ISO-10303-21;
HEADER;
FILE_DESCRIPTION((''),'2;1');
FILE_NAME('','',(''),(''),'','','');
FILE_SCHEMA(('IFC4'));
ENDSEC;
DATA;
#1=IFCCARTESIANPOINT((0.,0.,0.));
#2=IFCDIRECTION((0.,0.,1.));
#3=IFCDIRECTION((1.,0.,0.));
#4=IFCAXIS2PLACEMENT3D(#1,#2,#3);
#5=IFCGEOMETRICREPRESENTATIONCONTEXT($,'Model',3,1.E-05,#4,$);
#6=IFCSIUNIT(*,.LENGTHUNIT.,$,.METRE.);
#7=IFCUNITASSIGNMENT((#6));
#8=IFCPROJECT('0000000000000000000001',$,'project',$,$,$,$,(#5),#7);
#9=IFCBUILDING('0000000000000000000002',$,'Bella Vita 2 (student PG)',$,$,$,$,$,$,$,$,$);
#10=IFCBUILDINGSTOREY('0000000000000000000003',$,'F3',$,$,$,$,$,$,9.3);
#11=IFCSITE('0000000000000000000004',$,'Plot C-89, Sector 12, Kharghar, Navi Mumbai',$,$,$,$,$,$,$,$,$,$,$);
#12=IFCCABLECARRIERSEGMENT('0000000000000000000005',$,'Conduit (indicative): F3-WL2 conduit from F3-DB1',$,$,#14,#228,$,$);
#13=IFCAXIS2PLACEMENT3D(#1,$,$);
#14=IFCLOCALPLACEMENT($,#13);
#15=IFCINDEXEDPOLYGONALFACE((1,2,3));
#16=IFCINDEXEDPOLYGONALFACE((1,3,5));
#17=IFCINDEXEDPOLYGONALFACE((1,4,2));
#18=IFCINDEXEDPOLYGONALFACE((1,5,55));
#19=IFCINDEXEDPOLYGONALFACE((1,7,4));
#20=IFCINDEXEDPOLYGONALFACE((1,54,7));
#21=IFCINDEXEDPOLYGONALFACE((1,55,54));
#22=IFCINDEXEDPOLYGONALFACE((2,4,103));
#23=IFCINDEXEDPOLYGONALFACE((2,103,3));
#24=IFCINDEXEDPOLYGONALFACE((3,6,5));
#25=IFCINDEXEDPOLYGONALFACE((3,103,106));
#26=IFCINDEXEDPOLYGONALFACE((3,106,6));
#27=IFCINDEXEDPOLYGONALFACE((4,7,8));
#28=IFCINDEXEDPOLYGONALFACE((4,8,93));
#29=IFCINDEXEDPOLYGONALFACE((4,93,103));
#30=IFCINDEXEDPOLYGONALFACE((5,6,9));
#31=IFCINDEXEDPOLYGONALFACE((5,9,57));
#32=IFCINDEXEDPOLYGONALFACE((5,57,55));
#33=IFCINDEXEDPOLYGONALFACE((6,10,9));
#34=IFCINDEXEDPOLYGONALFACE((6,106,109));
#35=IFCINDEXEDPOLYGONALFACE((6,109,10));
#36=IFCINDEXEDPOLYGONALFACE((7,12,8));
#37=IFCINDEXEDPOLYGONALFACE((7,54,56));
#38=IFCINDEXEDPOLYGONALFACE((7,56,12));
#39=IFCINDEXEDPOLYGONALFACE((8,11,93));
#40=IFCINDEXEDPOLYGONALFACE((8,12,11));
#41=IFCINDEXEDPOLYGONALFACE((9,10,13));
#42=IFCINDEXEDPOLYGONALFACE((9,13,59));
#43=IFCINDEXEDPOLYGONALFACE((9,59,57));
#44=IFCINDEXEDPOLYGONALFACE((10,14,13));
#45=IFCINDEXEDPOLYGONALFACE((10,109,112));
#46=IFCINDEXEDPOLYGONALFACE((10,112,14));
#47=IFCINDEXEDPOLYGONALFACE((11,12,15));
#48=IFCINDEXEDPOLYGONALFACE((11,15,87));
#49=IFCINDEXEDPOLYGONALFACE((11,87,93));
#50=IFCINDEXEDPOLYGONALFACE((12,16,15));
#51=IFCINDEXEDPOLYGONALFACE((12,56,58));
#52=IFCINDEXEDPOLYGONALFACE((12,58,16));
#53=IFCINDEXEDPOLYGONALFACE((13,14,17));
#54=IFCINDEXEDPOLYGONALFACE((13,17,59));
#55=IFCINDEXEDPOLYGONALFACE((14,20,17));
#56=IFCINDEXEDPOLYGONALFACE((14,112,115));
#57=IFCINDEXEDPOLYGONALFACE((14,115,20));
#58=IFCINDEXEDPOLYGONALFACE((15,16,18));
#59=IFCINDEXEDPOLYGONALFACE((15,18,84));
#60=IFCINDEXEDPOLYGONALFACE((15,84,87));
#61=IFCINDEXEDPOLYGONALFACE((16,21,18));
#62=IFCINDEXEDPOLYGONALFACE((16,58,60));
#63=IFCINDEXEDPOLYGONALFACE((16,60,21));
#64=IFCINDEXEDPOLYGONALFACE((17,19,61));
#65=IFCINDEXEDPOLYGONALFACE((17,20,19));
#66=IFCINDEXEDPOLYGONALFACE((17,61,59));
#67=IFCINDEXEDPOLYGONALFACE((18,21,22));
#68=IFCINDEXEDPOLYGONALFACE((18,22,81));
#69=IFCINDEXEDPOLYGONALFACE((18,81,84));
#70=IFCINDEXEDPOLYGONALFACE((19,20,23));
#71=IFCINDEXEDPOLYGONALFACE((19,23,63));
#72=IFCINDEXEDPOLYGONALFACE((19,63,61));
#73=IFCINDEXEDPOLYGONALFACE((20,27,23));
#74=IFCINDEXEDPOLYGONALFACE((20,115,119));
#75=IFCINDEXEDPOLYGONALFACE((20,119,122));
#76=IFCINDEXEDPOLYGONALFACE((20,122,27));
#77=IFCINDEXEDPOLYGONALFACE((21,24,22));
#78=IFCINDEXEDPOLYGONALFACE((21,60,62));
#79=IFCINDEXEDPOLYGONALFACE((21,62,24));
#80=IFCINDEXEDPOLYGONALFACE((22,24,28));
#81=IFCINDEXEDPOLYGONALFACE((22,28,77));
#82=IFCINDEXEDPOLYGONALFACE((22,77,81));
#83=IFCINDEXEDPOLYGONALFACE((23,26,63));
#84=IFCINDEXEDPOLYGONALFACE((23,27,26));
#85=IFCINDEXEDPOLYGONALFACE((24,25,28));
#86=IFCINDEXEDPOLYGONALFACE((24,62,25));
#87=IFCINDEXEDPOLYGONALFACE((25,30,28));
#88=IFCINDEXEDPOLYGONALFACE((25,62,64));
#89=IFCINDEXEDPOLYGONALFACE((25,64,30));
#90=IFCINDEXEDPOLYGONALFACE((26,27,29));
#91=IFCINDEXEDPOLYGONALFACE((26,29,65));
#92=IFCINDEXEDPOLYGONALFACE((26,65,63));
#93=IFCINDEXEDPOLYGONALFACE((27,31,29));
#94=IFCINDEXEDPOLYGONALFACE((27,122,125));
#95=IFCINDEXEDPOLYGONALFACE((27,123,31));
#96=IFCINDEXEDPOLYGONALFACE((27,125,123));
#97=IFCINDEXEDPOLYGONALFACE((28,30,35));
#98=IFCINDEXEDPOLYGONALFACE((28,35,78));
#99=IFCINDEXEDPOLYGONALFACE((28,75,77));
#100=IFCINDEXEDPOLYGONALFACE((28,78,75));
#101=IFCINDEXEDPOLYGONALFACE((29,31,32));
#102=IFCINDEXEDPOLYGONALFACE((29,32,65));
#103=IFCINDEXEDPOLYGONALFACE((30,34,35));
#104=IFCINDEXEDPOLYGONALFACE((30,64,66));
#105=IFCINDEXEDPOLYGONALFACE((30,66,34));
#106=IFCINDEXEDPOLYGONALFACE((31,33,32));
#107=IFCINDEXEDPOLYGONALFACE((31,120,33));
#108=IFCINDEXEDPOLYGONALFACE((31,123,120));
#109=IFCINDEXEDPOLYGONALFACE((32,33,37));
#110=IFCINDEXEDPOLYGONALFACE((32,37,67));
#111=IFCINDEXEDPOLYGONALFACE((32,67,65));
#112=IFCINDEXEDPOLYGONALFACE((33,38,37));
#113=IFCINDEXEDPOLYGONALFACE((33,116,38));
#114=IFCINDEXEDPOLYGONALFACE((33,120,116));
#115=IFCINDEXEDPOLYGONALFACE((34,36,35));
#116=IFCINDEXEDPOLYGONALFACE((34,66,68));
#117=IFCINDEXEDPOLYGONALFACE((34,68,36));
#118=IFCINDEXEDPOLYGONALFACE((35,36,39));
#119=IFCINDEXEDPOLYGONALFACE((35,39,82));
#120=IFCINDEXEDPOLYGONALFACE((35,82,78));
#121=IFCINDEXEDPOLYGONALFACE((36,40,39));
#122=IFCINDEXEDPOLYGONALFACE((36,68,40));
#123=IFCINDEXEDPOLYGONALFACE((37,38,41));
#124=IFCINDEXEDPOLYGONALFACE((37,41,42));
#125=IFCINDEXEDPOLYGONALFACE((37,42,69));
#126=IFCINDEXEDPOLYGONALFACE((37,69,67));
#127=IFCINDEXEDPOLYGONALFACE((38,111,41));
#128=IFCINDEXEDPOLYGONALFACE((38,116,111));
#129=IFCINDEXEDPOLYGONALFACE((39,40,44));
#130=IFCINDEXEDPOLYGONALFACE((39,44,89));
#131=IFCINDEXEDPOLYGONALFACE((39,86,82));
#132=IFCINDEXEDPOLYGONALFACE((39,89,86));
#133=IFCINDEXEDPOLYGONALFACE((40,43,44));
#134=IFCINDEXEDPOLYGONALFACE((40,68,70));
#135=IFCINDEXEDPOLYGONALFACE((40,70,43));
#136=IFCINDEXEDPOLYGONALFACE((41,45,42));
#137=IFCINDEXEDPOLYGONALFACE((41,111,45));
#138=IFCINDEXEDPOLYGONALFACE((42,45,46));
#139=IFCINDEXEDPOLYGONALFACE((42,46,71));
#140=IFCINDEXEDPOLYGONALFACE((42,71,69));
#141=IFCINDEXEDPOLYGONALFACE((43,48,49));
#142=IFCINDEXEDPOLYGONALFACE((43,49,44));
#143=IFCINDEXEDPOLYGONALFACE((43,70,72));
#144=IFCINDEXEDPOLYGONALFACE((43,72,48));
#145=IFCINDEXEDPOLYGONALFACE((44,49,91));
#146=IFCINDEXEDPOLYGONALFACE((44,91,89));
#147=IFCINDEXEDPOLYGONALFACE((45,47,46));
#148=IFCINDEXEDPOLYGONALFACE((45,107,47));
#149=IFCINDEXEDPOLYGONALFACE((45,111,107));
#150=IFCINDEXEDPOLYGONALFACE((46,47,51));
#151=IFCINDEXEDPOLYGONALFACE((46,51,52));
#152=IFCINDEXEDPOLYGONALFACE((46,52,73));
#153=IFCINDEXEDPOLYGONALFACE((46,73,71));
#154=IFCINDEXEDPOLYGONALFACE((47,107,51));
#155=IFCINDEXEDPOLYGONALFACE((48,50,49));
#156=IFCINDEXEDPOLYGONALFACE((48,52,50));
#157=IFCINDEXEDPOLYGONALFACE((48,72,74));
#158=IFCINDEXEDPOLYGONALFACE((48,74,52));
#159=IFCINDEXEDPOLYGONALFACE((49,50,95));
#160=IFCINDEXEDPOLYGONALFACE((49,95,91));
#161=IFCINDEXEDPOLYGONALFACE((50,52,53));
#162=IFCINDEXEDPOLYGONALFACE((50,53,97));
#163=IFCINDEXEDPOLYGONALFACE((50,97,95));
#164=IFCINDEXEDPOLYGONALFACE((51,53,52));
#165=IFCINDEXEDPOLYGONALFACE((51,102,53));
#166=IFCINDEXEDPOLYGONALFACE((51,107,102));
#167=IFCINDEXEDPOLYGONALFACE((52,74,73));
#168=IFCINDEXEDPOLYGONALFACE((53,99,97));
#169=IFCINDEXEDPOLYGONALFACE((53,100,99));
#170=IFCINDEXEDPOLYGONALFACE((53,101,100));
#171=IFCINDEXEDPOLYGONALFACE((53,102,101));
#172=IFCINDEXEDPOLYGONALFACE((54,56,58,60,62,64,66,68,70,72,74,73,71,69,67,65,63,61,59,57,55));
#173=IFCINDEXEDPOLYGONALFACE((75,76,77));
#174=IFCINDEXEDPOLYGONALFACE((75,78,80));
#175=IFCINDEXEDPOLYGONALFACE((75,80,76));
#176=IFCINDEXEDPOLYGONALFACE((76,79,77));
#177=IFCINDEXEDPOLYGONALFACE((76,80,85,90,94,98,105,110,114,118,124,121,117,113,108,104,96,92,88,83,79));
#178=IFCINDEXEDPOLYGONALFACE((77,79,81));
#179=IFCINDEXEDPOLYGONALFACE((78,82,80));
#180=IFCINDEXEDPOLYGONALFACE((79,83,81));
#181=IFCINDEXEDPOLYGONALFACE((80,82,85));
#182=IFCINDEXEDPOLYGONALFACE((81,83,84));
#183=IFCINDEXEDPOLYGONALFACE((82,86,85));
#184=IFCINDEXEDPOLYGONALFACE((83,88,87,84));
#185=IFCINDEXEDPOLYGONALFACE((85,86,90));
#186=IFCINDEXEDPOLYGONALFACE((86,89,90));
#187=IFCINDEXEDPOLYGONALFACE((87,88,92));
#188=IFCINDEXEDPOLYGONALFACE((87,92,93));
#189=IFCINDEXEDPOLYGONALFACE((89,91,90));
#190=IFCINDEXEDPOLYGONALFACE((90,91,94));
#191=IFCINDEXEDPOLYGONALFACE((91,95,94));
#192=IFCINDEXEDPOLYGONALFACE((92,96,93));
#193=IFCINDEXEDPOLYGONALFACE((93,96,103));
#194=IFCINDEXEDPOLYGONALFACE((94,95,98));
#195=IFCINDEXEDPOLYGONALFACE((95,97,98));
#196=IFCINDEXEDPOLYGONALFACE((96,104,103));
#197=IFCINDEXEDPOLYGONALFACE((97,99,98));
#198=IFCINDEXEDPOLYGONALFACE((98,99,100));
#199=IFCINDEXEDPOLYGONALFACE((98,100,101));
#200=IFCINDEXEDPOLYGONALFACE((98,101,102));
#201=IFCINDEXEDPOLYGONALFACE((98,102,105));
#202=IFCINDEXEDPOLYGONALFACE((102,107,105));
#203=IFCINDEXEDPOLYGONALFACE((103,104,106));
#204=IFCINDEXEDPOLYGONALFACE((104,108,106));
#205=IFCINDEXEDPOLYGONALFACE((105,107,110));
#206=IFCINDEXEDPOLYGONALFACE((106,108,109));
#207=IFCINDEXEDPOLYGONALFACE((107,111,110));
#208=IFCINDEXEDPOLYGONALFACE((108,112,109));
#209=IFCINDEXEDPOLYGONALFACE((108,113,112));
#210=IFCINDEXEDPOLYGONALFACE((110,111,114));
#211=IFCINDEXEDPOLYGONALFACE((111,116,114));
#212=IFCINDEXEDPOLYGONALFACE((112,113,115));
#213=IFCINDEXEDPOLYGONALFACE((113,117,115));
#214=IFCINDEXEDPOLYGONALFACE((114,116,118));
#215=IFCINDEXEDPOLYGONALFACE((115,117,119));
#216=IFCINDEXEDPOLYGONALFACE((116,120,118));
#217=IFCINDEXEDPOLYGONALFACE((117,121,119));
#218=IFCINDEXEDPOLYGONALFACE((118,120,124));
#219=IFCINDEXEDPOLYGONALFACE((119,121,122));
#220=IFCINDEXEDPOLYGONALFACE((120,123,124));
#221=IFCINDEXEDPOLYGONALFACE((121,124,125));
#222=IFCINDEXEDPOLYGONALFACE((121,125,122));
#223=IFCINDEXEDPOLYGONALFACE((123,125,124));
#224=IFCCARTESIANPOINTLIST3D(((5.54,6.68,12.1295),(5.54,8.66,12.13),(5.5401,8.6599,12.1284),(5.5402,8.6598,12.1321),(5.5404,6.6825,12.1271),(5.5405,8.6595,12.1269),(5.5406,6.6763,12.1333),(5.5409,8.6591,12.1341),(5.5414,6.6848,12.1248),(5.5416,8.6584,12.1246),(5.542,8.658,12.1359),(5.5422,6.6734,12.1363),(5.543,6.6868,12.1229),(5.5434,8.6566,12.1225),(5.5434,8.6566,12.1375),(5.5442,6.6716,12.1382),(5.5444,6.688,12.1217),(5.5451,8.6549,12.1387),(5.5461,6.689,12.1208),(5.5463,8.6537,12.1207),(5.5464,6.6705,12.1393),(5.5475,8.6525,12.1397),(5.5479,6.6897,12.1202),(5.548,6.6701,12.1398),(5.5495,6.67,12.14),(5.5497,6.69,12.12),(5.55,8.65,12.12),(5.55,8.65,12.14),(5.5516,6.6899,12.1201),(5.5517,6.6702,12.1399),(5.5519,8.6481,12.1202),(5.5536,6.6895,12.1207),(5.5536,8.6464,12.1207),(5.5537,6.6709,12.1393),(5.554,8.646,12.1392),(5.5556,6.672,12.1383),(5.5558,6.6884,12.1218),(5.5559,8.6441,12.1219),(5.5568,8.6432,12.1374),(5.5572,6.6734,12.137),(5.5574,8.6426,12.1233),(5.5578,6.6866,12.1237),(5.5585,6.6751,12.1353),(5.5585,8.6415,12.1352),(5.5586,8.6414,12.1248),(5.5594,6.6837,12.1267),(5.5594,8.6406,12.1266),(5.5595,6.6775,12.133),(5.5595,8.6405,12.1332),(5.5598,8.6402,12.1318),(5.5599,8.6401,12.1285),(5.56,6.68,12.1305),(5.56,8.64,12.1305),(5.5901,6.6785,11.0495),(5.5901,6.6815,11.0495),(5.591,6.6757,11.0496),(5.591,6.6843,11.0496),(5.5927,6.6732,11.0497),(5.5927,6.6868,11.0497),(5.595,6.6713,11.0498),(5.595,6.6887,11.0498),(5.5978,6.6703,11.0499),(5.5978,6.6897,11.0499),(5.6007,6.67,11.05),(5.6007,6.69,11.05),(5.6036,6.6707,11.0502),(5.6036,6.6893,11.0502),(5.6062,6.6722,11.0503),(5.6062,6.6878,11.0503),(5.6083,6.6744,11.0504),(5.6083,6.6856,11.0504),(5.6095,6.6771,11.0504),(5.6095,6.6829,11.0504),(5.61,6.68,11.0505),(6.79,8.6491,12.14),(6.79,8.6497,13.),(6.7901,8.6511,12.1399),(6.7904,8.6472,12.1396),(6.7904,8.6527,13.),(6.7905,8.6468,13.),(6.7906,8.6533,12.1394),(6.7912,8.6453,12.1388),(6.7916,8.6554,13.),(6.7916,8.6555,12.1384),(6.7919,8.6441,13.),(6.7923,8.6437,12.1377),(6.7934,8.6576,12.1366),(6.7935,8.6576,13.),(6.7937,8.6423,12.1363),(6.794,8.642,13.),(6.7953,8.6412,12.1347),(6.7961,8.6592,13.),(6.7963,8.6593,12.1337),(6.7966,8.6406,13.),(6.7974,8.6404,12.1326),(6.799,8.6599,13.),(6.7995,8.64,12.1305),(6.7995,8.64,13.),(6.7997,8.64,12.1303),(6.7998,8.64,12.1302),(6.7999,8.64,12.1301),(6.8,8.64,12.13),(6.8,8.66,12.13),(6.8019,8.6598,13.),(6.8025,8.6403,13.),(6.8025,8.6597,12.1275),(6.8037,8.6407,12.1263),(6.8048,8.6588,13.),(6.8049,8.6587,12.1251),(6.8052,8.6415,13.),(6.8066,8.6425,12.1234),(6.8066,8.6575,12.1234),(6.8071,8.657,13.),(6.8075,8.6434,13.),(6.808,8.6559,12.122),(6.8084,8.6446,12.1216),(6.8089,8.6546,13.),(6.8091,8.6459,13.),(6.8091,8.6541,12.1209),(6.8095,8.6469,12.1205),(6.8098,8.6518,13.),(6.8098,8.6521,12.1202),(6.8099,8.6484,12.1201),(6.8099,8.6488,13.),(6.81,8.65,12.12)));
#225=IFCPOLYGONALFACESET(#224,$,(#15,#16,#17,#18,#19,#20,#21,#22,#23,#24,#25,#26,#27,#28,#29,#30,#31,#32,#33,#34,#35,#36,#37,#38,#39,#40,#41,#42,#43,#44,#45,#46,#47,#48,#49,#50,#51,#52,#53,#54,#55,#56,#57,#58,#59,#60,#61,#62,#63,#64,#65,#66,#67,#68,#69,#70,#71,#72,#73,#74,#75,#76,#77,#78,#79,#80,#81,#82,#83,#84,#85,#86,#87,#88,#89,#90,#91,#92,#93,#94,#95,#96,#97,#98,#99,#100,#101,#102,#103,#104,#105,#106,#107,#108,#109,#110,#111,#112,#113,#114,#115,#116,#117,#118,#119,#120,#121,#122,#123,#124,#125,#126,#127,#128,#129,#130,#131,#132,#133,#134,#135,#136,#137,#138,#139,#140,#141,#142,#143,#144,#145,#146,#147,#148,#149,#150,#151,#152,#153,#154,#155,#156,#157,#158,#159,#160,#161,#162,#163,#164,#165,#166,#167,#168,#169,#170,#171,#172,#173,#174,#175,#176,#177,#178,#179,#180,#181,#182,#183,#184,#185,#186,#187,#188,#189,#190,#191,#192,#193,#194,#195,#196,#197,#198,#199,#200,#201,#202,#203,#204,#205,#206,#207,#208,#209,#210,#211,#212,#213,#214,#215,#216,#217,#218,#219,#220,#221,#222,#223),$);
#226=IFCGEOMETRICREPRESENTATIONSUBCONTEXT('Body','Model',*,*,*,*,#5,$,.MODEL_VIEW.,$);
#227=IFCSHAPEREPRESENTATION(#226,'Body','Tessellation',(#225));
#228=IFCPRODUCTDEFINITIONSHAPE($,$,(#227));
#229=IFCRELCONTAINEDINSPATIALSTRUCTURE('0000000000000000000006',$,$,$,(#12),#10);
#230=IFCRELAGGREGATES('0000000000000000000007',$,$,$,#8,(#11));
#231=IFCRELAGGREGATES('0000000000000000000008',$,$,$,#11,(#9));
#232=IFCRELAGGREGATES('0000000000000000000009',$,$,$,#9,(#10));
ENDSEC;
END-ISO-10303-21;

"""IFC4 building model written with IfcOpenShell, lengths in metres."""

from ifc_helpers import new_model, entity, si_unit, origin, origin_with_axes, place, context, subcontext, project, spatial, element, save


model = new_model("IFC4")

# Units and contexts
model_context = context("Model", 3, precision=1e-05, world=origin_with_axes())
body_context = subcontext(model_context, "Body", "Model", "MODEL_VIEW")
ifc_project = project(units=[si_unit("LENGTHUNIT", "METRE")], contexts=[model_context])

# Site, building, storey
site = spatial("IfcSite", under=ifc_project, Name="Plot C-89, Sector 12, Kharghar, Navi Mumbai")
building = spatial("IfcBuilding", under=site, Name="Bella Vita 2 (student PG)")
storey = spatial("IfcBuildingStorey", under=building, Name="F3", Elevation=9.3)

# Cable carrier segment
cable_carrier_segment_1_placement = place(None, origin())
element("IfcCableCarrierSegment", 1, at=cable_carrier_segment_1_placement, inside=storey, Name="Conduit (indicative): F3-WL2 conduit from F3-DB1", context=body_context, shape_type="AdvancedSweptSolid", body=[
    entity("IfcSweptDiskSolid", entity("IfcPolyline", [entity("IfcCartesianPoint", [5.6, 6.68, 11.05]), entity("IfcCartesianPoint", [5.55, 6.68, 12.13]), entity("IfcCartesianPoint", [5.55, 8.65, 12.13]), entity("IfcCartesianPoint", [6.8, 8.65, 12.13]), entity("IfcCartesianPoint", [6.8, 8.65, 13.0])]), 0.01),
])

save(model, "model.ifc")
